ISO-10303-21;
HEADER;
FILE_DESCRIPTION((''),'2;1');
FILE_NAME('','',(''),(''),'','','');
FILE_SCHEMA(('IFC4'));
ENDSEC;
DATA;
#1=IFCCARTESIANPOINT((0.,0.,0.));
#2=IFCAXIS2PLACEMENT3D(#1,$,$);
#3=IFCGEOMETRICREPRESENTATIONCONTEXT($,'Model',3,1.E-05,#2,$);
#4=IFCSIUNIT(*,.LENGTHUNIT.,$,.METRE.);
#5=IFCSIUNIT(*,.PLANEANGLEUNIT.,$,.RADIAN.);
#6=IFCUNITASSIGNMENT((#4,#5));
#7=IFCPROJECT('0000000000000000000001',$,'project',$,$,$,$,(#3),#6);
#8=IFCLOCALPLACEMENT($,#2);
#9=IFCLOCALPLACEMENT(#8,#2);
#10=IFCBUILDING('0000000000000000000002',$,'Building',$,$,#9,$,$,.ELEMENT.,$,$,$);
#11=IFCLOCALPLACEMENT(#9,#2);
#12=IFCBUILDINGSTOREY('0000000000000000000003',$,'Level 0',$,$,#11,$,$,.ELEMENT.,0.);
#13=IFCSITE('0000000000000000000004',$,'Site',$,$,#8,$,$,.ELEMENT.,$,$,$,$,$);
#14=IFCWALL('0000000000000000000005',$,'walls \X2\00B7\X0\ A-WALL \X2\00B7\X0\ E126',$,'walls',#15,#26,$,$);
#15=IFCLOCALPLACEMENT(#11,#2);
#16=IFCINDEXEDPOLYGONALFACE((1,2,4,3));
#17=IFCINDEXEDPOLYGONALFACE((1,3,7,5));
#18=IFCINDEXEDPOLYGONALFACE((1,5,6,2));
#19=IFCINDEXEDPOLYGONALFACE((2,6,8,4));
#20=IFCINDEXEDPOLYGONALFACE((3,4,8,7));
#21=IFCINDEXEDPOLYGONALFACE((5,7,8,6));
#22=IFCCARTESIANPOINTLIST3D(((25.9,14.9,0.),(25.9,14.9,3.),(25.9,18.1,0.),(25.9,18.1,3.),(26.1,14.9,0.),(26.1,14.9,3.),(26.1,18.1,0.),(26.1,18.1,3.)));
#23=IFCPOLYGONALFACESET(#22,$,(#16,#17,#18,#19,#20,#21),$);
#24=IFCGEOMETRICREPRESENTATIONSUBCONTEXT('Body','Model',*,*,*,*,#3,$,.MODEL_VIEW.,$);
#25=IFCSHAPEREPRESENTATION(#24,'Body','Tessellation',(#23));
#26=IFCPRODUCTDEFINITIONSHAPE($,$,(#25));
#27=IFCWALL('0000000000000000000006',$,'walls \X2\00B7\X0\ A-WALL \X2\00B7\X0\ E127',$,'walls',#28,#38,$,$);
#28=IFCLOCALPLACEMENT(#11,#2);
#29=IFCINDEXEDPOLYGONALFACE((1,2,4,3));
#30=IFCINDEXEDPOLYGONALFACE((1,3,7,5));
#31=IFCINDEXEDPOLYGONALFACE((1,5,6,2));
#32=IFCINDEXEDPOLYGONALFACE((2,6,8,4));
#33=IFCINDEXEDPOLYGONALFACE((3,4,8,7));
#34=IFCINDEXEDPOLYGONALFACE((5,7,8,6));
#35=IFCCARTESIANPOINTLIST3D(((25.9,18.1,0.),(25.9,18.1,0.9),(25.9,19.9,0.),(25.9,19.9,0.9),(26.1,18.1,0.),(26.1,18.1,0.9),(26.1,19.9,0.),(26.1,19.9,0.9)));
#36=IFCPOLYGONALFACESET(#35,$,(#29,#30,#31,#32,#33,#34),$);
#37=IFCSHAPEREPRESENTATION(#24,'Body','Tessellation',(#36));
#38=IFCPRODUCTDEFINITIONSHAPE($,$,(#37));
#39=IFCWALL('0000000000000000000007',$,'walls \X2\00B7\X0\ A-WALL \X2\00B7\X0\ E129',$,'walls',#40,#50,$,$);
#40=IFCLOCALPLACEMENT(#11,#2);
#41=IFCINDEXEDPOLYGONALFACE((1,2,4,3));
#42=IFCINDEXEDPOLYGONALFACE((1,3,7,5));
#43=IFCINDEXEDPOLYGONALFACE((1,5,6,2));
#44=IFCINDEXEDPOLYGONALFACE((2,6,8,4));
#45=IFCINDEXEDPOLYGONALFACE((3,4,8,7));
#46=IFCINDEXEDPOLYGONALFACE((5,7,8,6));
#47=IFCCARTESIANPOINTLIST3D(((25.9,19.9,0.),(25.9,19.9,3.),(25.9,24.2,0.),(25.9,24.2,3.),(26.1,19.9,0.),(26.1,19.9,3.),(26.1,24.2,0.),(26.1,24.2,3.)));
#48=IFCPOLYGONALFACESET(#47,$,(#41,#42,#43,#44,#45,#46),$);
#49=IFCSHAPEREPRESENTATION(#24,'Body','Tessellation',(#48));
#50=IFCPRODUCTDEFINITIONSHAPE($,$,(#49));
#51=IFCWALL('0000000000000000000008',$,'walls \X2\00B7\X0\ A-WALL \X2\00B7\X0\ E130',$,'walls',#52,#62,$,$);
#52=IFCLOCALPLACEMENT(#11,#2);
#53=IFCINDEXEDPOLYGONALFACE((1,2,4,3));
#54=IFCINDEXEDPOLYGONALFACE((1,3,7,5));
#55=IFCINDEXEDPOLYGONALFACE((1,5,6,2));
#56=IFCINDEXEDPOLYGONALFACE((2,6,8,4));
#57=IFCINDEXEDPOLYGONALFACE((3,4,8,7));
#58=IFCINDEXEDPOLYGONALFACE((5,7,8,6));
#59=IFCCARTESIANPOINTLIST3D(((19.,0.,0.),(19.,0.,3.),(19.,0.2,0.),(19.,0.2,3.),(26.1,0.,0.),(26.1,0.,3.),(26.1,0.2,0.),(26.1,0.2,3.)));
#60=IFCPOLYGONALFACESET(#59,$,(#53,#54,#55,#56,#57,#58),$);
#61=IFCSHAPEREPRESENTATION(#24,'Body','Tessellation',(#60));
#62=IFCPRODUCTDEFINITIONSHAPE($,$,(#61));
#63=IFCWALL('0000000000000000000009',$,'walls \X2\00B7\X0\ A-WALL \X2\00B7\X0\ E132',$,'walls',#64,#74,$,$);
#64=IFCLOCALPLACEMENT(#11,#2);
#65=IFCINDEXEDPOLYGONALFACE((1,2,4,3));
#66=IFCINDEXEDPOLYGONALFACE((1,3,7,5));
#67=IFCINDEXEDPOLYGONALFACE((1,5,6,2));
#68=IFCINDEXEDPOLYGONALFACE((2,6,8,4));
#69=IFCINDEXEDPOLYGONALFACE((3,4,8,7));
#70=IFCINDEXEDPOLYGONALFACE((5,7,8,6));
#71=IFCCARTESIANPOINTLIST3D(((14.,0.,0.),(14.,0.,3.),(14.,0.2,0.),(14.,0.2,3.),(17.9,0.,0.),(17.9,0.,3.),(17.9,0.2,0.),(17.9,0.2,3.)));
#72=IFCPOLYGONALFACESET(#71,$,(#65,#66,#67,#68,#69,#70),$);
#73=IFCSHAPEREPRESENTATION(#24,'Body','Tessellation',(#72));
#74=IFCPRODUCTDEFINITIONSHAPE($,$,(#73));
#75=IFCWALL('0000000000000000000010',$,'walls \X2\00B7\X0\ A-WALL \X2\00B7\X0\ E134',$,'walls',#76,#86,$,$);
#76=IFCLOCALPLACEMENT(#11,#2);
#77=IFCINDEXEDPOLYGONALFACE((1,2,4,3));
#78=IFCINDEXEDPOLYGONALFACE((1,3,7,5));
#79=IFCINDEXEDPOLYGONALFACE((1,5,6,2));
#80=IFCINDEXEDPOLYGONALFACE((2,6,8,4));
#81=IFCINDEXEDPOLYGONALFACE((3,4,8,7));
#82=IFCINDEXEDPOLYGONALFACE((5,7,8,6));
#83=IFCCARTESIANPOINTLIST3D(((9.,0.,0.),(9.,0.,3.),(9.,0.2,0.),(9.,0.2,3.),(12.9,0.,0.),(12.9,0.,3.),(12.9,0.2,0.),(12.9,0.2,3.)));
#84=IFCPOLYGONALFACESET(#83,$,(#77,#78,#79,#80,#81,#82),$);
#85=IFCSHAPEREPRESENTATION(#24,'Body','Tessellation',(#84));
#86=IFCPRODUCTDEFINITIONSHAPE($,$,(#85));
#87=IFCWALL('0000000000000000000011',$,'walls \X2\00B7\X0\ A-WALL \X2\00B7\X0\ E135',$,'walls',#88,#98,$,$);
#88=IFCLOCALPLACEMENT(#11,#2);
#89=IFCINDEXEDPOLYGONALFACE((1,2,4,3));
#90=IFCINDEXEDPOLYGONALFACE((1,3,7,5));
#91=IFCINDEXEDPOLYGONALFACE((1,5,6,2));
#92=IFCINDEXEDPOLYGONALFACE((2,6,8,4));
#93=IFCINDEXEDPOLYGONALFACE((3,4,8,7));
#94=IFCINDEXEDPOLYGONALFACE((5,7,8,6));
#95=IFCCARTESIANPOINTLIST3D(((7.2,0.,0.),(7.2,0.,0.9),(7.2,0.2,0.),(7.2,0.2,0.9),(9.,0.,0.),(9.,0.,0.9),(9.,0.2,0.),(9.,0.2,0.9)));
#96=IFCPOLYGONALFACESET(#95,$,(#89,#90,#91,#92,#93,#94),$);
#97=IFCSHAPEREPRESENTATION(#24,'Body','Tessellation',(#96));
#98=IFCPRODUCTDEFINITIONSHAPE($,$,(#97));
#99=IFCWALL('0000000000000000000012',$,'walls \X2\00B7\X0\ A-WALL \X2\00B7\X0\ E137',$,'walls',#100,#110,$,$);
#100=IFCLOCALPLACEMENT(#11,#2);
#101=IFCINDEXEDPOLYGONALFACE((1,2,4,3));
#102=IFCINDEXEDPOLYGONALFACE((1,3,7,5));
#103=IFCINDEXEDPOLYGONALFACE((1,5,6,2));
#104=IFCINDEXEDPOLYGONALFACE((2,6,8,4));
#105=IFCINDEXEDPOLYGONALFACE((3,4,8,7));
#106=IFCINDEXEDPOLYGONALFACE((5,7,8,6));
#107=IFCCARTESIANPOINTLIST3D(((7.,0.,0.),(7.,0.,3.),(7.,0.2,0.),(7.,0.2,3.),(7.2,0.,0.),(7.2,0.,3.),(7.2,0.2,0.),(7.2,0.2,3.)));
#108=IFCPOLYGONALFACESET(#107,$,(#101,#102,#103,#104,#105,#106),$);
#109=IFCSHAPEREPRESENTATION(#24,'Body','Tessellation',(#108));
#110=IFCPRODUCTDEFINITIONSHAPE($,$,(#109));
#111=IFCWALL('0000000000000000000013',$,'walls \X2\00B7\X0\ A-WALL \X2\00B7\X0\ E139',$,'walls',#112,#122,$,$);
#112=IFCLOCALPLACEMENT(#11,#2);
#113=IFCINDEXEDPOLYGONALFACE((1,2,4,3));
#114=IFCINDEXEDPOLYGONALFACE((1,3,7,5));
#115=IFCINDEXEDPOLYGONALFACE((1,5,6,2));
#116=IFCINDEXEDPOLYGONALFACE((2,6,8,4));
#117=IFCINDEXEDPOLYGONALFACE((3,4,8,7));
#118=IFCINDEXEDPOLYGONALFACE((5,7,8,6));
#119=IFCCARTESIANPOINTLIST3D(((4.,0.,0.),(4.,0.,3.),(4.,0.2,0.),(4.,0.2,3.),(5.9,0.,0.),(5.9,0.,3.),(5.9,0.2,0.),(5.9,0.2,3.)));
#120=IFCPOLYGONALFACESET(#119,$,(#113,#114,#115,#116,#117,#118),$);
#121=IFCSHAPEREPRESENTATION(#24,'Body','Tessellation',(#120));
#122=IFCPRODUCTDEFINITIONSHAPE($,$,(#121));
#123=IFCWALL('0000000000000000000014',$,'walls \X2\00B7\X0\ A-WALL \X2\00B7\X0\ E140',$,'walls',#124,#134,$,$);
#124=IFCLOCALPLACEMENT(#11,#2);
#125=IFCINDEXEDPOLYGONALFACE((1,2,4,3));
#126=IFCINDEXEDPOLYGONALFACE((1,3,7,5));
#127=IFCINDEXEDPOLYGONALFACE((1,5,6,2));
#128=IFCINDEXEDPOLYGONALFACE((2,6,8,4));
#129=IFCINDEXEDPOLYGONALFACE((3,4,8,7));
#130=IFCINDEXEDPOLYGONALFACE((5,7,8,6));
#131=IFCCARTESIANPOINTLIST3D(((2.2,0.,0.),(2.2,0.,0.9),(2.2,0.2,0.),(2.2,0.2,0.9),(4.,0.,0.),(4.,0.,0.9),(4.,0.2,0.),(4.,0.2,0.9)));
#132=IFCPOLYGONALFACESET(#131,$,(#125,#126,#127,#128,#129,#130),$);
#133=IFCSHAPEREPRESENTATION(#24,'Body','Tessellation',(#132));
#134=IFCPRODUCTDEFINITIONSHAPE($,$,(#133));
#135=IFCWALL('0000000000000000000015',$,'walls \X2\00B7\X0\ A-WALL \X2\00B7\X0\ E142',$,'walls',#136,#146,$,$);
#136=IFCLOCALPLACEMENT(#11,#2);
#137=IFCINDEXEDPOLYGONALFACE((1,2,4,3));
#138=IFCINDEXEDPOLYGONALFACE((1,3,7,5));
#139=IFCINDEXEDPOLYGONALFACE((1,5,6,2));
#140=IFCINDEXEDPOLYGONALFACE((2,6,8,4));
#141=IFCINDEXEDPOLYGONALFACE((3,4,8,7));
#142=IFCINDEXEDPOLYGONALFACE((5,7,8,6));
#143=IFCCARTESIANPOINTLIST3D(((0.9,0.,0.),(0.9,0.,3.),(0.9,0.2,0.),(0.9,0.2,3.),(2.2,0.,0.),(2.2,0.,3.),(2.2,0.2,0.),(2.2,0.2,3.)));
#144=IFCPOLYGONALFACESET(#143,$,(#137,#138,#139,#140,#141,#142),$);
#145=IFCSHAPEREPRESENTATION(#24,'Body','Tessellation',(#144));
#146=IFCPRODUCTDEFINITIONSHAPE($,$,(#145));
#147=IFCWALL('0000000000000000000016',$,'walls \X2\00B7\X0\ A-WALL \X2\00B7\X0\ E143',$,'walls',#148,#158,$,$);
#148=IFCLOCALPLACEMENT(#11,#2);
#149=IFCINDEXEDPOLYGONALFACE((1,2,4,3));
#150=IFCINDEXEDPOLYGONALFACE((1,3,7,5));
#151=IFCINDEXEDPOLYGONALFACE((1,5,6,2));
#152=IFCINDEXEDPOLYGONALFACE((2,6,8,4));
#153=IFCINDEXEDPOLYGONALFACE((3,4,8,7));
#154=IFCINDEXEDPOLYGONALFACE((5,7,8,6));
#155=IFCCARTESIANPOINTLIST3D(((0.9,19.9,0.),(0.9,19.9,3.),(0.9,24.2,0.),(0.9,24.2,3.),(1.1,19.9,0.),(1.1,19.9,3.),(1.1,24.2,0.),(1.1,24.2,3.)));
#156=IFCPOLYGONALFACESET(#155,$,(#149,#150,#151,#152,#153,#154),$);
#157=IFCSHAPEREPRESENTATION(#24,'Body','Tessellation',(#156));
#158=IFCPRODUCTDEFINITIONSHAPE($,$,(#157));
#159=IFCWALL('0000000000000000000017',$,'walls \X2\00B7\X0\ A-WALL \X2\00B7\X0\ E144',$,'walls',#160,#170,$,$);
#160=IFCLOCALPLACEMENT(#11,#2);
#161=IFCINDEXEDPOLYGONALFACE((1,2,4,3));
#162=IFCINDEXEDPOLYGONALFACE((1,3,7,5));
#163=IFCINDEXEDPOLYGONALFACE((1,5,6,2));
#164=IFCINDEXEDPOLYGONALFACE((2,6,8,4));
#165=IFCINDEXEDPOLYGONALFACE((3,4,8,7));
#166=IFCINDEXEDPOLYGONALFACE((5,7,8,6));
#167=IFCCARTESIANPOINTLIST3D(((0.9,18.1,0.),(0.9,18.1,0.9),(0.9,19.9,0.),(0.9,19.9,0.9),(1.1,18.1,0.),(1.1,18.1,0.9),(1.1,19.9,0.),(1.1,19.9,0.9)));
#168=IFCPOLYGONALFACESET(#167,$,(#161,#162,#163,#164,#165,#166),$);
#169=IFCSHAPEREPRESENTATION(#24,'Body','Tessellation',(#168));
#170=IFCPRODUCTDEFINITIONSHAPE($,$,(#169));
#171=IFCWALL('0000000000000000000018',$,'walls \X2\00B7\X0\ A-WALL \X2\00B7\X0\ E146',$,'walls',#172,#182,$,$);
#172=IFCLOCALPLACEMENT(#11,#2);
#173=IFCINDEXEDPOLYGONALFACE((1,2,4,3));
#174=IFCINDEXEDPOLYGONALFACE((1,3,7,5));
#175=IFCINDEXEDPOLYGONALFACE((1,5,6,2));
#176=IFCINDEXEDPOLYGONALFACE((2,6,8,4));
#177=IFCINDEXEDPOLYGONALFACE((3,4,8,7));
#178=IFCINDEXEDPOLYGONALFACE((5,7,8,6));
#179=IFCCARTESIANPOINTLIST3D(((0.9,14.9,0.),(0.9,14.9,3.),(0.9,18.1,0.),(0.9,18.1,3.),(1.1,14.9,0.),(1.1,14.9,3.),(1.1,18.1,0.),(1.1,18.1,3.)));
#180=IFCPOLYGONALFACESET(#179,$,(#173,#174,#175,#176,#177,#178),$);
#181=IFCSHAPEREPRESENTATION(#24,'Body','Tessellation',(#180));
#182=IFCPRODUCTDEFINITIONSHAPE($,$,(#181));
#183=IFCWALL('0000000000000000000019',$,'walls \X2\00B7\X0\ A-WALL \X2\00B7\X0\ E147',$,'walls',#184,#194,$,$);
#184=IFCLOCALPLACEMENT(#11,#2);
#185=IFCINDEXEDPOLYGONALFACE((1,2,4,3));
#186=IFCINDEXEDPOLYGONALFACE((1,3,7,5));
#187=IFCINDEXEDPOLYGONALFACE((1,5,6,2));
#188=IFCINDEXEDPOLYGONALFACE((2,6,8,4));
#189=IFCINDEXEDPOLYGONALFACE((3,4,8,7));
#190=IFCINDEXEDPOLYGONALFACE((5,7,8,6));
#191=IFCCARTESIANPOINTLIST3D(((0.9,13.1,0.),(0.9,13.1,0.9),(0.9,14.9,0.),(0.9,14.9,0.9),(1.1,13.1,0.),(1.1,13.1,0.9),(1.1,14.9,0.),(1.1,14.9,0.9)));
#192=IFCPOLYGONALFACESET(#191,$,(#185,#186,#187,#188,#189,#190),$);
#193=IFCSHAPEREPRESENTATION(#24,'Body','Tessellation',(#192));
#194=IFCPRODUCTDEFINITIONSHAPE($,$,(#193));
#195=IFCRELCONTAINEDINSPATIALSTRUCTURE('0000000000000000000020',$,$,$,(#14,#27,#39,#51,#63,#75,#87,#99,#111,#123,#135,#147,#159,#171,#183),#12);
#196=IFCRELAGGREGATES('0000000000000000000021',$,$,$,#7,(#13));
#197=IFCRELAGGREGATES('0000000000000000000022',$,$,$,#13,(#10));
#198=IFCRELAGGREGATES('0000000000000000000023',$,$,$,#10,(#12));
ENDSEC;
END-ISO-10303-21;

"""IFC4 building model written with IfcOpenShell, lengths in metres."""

from ifc_helpers import new_model, si_unit, frame, origin, place, context, subcontext, project, spatial, polyline, outline, extrude, element, save


model = new_model("IFC4")

# Units and contexts
model_context = context("Model", 3, precision=1e-05, world=origin())
body_context = subcontext(model_context, "Body", "Model", "MODEL_VIEW")
ifc_project = project(units=[si_unit("LENGTHUNIT", "METRE"), si_unit("PLANEANGLEUNIT", "RADIAN")], contexts=[model_context])

# Site, building, storey
site_placement = place(None, origin())
site = spatial("IfcSite", under=ifc_project, at=site_placement, Name="Site", CompositionType="ELEMENT")
building_placement = place(site_placement, origin())
building = spatial("IfcBuilding", under=site, at=building_placement, Name="Building", CompositionType="ELEMENT")
storey_placement = place(building_placement, origin())
storey = spatial("IfcBuildingStorey", under=building, at=storey_placement, Name="Level 0", CompositionType="ELEMENT", Elevation=0.0)

# Wall
wall_1_placement = place(storey_placement, origin())
element("IfcWall", 1, at=wall_1_placement, inside=storey, Name="walls · A-WALL · E126", ObjectType="walls", context=body_context, shape_type="SweptSolid", body=[
    extrude(outline(polyline([(26.1, 14.9), (26.1, 18.1), (25.9, 18.1), (25.9, 14.9), (26.1, 14.9)])), origin(), (0.0, 0.0, 1.0), 3.0),
])

# Wall, opening
wall_2_placement = place(storey_placement, origin())
wall_2 = element("IfcWall", 2, at=wall_2_placement, inside=storey, Name="walls · A-WALL · E127", ObjectType="walls", context=body_context, shape_type="SweptSolid", body=[
    extrude(outline(polyline([(26.1, 18.1), (26.1, 19.9), (25.9, 19.9), (25.9, 18.1), (26.1, 18.1)])), origin(), (0.0, 0.0, 1.0), 0.9),
])
opening_1_placement = place(storey_placement, frame((0.0, 0.0, 0.9)))
element("IfcOpeningElement", 3, at=opening_1_placement, cuts=wall_2, ObjectType="Opening", context=body_context, shape_type="SweptSolid", body=[
    extrude(outline(polyline([(26.1, 18.1), (26.1, 19.9), (25.9, 19.9), (25.9, 18.1), (26.1, 18.1)])), origin(), (0.0, 0.0, 1.0), 1.4),
])

# Walls
wall_3_placement = place(storey_placement, origin())
element("IfcWall", 4, at=wall_3_placement, inside=storey, Name="walls · A-WALL · E129", ObjectType="walls", context=body_context, shape_type="SweptSolid", body=[
    extrude(outline(polyline([(26.1, 19.9), (26.1, 24.2), (25.9, 24.2), (25.9, 19.9), (26.1, 19.9)])), origin(), (0.0, 0.0, 1.0), 3.0),
])
wall_4_placement = place(storey_placement, origin())
element("IfcWall", 5, at=wall_4_placement, inside=storey, Name="walls · A-WALL · E130", ObjectType="walls", context=body_context, shape_type="SweptSolid", body=[
    extrude(outline(polyline([(26.1, 0.2), (19.0, 0.2), (19.0, 0.0), (26.1, 0.0), (26.1, 0.2)])), origin(), (0.0, 0.0, 1.0), 3.0),
])
wall_5_placement = place(storey_placement, origin())
element("IfcWall", 6, at=wall_5_placement, inside=storey, Name="walls · A-WALL · E132", ObjectType="walls", context=body_context, shape_type="SweptSolid", body=[
    extrude(outline(polyline([(17.9, 0.2), (14.0, 0.2), (14.0, 0.0), (17.9, 0.0), (17.9, 0.2)])), origin(), (0.0, 0.0, 1.0), 3.0),
])
wall_6_placement = place(storey_placement, origin())
element("IfcWall", 7, at=wall_6_placement, inside=storey, Name="walls · A-WALL · E134", ObjectType="walls", context=body_context, shape_type="SweptSolid", body=[
    extrude(outline(polyline([(12.9, 0.2), (9.0, 0.2), (9.0, 0.0), (12.9, 0.0), (12.9, 0.2)])), origin(), (0.0, 0.0, 1.0), 3.0),
])

# Wall, opening
wall_7_placement = place(storey_placement, origin())
wall_7 = element("IfcWall", 8, at=wall_7_placement, inside=storey, Name="walls · A-WALL · E135", ObjectType="walls", context=body_context, shape_type="SweptSolid", body=[
    extrude(outline(polyline([(9.0, 0.2), (7.2, 0.2), (7.2, 0.0), (9.0, 0.0), (9.0, 0.2)])), origin(), (0.0, 0.0, 1.0), 0.9),
])
opening_2_placement = place(storey_placement, frame((0.0, 0.0, 0.9)))
element("IfcOpeningElement", 9, at=opening_2_placement, cuts=wall_7, ObjectType="Opening", context=body_context, shape_type="SweptSolid", body=[
    extrude(outline(polyline([(9.0, 0.2), (7.2, 0.2), (7.2, 0.0), (9.0, 0.0), (9.0, 0.2)])), origin(), (0.0, 0.0, 1.0), 1.4),
])

# Walls
wall_8_placement = place(storey_placement, origin())
element("IfcWall", 10, at=wall_8_placement, inside=storey, Name="walls · A-WALL · E137", ObjectType="walls", context=body_context, shape_type="SweptSolid", body=[
    extrude(outline(polyline([(7.2, 0.2), (7.0, 0.2), (7.0, 0.0), (7.2, 0.0), (7.2, 0.2)])), origin(), (0.0, 0.0, 1.0), 3.0),
])
wall_9_placement = place(storey_placement, origin())
element("IfcWall", 11, at=wall_9_placement, inside=storey, Name="walls · A-WALL · E139", ObjectType="walls", context=body_context, shape_type="SweptSolid", body=[
    extrude(outline(polyline([(5.9, 0.2), (4.0, 0.2), (4.0, 0.0), (5.9, 0.0), (5.9, 0.2)])), origin(), (0.0, 0.0, 1.0), 3.0),
])

# Wall, opening
wall_10_placement = place(storey_placement, origin())
wall_10 = element("IfcWall", 12, at=wall_10_placement, inside=storey, Name="walls · A-WALL · E140", ObjectType="walls", context=body_context, shape_type="SweptSolid", body=[
    extrude(outline(polyline([(4.0, 0.2), (2.2, 0.2), (2.2, 0.0), (4.0, 0.0), (4.0, 0.2)])), origin(), (0.0, 0.0, 1.0), 0.9),
])
opening_3_placement = place(storey_placement, frame((0.0, 0.0, 0.9)))
element("IfcOpeningElement", 13, at=opening_3_placement, cuts=wall_10, ObjectType="Opening", context=body_context, shape_type="SweptSolid", body=[
    extrude(outline(polyline([(4.0, 0.2), (2.2, 0.2), (2.2, 0.0), (4.0, 0.0), (4.0, 0.2)])), origin(), (0.0, 0.0, 1.0), 1.4),
])

# Walls
wall_11_placement = place(storey_placement, origin())
element("IfcWall", 14, at=wall_11_placement, inside=storey, Name="walls · A-WALL · E142", ObjectType="walls", context=body_context, shape_type="SweptSolid", body=[
    extrude(outline(polyline([(2.2, 0.2), (0.9, 0.2), (0.9, 0.0), (2.2, 0.0), (2.2, 0.2)])), origin(), (0.0, 0.0, 1.0), 3.0),
])
wall_12_placement = place(storey_placement, origin())
element("IfcWall", 15, at=wall_12_placement, inside=storey, Name="walls · A-WALL · E143", ObjectType="walls", context=body_context, shape_type="SweptSolid", body=[
    extrude(outline(polyline([(0.9, 24.2), (0.9, 19.9), (1.1, 19.9), (1.1, 24.2), (0.9, 24.2)])), origin(), (0.0, 0.0, 1.0), 3.0),
])

# Wall, opening
wall_13_placement = place(storey_placement, origin())
wall_13 = element("IfcWall", 16, at=wall_13_placement, inside=storey, Name="walls · A-WALL · E144", ObjectType="walls", context=body_context, shape_type="SweptSolid", body=[
    extrude(outline(polyline([(0.9, 19.9), (0.9, 18.1), (1.1, 18.1), (1.1, 19.9), (0.9, 19.9)])), origin(), (0.0, 0.0, 1.0), 0.9),
])
opening_4_placement = place(storey_placement, frame((0.0, 0.0, 0.9)))
element("IfcOpeningElement", 17, at=opening_4_placement, cuts=wall_13, ObjectType="Opening", context=body_context, shape_type="SweptSolid", body=[
    extrude(outline(polyline([(0.9, 19.9), (0.9, 18.1), (1.1, 18.1), (1.1, 19.9), (0.9, 19.9)])), origin(), (0.0, 0.0, 1.0), 1.4),
])

# Wall
wall_14_placement = place(storey_placement, origin())
element("IfcWall", 18, at=wall_14_placement, inside=storey, Name="walls · A-WALL · E146", ObjectType="walls", context=body_context, shape_type="SweptSolid", body=[
    extrude(outline(polyline([(0.9, 18.1), (0.9, 14.9), (1.1, 14.9), (1.1, 18.1), (0.9, 18.1)])), origin(), (0.0, 0.0, 1.0), 3.0),
])

# Wall, opening
wall_15_placement = place(storey_placement, origin())
wall_15 = element("IfcWall", 19, at=wall_15_placement, inside=storey, Name="walls · A-WALL · E147", ObjectType="walls", context=body_context, shape_type="SweptSolid", body=[
    extrude(outline(polyline([(0.9, 14.9), (0.9, 13.1), (1.1, 13.1), (1.1, 14.9), (0.9, 14.9)])), origin(), (0.0, 0.0, 1.0), 0.9),
])
opening_5_placement = place(storey_placement, frame((0.0, 0.0, 0.9)))
element("IfcOpeningElement", 20, at=opening_5_placement, cuts=wall_15, ObjectType="Opening", context=body_context, shape_type="SweptSolid", body=[
    extrude(outline(polyline([(0.9, 14.9), (0.9, 13.1), (1.1, 13.1), (1.1, 14.9), (0.9, 14.9)])), origin(), (0.0, 0.0, 1.0), 1.4),
])

save(model, "model.ifc")
